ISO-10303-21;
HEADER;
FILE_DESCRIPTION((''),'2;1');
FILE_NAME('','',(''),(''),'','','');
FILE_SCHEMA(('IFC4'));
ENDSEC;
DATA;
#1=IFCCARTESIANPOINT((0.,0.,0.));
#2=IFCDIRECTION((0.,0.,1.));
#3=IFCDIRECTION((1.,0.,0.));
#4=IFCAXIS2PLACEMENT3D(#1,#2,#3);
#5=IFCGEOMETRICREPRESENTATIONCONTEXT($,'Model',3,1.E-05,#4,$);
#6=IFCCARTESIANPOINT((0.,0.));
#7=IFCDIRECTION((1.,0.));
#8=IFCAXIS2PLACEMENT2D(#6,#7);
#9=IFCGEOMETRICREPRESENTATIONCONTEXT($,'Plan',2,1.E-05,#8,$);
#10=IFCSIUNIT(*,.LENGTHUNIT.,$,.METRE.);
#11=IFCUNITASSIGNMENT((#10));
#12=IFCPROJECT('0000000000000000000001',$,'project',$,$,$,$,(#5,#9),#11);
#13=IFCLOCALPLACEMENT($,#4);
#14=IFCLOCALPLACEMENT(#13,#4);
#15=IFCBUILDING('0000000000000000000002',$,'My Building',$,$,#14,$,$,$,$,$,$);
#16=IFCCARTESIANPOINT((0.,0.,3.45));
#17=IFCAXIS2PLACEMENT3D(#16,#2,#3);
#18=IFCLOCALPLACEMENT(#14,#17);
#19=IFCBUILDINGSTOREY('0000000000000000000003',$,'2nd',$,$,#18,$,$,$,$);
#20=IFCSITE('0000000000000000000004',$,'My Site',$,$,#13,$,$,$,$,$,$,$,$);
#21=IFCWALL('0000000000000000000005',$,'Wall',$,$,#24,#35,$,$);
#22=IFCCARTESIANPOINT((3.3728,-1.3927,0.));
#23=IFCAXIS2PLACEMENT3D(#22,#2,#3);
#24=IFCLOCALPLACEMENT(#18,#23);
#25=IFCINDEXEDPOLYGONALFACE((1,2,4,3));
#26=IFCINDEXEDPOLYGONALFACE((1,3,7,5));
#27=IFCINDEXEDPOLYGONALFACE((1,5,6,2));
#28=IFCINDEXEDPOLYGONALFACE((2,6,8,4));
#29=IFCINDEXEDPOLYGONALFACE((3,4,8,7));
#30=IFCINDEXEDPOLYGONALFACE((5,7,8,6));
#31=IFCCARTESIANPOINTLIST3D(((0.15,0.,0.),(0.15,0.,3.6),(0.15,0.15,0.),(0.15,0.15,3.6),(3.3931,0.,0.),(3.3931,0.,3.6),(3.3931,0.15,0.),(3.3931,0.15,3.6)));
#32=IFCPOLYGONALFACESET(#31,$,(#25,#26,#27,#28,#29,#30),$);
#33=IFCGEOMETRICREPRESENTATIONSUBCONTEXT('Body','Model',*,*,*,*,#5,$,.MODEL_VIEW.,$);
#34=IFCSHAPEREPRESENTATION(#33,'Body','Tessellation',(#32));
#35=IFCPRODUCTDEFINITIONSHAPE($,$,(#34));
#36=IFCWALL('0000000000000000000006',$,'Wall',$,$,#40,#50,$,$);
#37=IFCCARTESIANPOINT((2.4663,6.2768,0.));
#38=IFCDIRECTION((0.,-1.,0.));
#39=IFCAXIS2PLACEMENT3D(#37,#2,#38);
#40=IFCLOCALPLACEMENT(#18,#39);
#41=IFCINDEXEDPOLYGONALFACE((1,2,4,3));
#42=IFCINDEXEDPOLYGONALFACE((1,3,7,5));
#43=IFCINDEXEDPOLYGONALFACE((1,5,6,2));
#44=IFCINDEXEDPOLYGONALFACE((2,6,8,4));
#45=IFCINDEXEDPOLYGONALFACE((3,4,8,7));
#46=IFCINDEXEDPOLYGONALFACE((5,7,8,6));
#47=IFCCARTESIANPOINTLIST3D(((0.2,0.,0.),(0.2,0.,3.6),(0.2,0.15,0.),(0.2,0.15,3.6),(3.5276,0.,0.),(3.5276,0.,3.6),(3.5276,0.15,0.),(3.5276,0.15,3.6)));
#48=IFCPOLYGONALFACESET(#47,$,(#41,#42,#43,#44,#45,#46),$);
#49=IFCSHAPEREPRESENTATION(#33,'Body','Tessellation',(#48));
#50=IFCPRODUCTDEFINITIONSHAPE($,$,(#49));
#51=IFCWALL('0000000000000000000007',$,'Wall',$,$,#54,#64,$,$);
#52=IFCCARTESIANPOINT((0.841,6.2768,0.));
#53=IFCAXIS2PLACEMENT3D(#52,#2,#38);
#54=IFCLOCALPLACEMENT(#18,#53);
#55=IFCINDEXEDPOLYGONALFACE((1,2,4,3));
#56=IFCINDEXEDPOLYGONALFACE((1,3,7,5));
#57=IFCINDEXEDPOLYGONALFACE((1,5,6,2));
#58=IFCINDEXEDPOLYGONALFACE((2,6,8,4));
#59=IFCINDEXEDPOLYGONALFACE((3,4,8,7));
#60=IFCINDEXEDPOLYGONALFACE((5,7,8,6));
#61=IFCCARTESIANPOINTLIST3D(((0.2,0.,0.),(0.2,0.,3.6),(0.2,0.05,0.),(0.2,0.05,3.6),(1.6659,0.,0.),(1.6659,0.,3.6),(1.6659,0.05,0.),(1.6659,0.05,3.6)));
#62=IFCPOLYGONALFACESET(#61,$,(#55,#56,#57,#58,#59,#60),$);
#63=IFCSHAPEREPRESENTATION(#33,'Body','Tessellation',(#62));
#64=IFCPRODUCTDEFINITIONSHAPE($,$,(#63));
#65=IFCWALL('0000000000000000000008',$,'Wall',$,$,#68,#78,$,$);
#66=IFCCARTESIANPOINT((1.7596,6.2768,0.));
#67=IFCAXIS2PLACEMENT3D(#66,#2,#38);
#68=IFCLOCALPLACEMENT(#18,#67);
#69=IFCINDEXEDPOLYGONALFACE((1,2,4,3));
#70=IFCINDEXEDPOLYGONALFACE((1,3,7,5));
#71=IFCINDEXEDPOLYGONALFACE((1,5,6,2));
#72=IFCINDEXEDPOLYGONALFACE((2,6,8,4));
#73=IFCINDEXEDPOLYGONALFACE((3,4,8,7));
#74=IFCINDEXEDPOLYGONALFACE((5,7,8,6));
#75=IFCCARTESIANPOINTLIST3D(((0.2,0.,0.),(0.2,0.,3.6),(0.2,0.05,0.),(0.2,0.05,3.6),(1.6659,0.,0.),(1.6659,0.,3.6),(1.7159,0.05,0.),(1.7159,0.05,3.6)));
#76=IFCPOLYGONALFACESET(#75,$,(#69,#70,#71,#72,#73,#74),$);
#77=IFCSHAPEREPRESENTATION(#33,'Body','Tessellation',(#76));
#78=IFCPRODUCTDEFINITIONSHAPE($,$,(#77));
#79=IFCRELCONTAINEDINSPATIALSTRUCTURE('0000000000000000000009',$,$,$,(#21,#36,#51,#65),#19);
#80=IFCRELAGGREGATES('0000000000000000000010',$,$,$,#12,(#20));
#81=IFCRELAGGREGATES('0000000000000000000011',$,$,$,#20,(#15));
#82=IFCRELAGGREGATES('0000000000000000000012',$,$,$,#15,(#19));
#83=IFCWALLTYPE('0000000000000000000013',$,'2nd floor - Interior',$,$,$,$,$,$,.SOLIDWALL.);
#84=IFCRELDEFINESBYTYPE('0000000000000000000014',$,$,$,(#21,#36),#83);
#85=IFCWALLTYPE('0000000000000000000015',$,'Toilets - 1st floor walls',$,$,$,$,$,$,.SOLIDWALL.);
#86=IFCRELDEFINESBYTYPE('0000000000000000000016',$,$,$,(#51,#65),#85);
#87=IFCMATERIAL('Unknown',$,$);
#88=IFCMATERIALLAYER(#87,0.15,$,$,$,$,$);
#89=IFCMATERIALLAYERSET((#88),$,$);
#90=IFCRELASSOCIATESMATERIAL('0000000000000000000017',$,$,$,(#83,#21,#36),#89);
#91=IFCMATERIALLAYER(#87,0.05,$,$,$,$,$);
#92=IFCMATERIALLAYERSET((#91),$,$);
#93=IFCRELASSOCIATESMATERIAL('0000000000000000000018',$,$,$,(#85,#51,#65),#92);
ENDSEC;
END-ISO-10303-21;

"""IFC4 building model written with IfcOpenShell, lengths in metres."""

from ifc_helpers import new_model, si_unit, frame, origin_with_axes, origin_2d_with_axis, place, context, subcontext, project, spatial, line, indexed_curve, outline, extrude, material, layer, layer_set, layer_usage, type_object, element, save


model = new_model("IFC4")

# Units and contexts
model_context = context("Model", 3, precision=1e-05, world=origin_with_axes())
plan_context = context("Plan", 2, precision=1e-05, world=origin_2d_with_axis())
body_context_1 = subcontext(model_context, "Body", "Model", "MODEL_VIEW")
ifc_project = project(units=[si_unit("LENGTHUNIT", "METRE")], contexts=[model_context, plan_context])

# Site, building, storey
site_placement = place(None, origin_with_axes())
site = spatial("IfcSite", under=ifc_project, at=site_placement, Name="My Site")
building_placement = place(site_placement, origin_with_axes())
building = spatial("IfcBuilding", under=site, at=building_placement, Name="My Building")
storey_placement = place(building_placement, frame((0.0, 0.0, 3.45), z_axis=(0.0, 0.0, 1.0), x_axis=(1.0, 0.0, 0.0)))
storey = spatial("IfcBuildingStorey", under=building, at=storey_placement, Name="2nd")

# Shared definitions
ifc_material = material(Name="Unknown")

# Shared definitions
ifc_layer_1 = layer(ifc_material, 0.15)
ifc_layer_set_1 = layer_set([ifc_layer_1])
wall_type_1 = type_object("IfcWallType", Name="2nd floor - Interior", PredefinedType="SOLIDWALL", material=ifc_layer_set_1)

# Walls
ifc_layer_usage_1 = layer_usage(ifc_layer_set_1, "AXIS2", "POSITIVE", 0.0)
wall_1_placement = place(storey_placement, frame((3.3728, -1.3927, 0.0), z_axis=(0.0, 0.0, 1.0), x_axis=(1.0, 0.0, 0.0)))
element("IfcWall", 1, at=wall_1_placement, inside=storey, type_object=wall_type_1, material=ifc_layer_usage_1, Name="Wall", context=body_context_1, shape_type="SweptSolid", body=[
    extrude(outline(indexed_curve([(0.15, 0.0), (0.15, 0.15), (3.3931, 0.15), (3.3931, 0.0)], segments=[line(1, 2, 3, 4, 1)])), origin_with_axes(), (0.0, 0.0, 1.0), 3.6),
])
ifc_layer_usage_2 = layer_usage(ifc_layer_set_1, "AXIS2", "POSITIVE", 0.0)
wall_2_placement = place(storey_placement, frame((2.4663, 6.2768, 0.0), z_axis=(0.0, 0.0, 1.0), x_axis=(0.0, -1.0, 0.0)))
element("IfcWall", 2, at=wall_2_placement, inside=storey, type_object=wall_type_1, material=ifc_layer_usage_2, Name="Wall", context=body_context_1, shape_type="SweptSolid", body=[
    extrude(outline(indexed_curve([(0.2, 0.0), (0.2, 0.15), (3.5276, 0.15), (3.5276, 0.0)], segments=[line(1, 2, 3, 4, 1)])), origin_with_axes(), (0.0, 0.0, 1.0), 3.6),
])
ifc_layer_2 = layer(ifc_material, 0.05)
ifc_layer_set_2 = layer_set([ifc_layer_2])
ifc_layer_usage_3 = layer_usage(ifc_layer_set_2, "AXIS2", "POSITIVE", 0.0)
wall_type_2 = type_object("IfcWallType", Name="Toilets - 1st floor walls", PredefinedType="SOLIDWALL", material=ifc_layer_set_2)
wall_3_placement = place(storey_placement, frame((0.841, 6.2768, 0.0), z_axis=(0.0, 0.0, 1.0), x_axis=(0.0, -1.0, 0.0)))
element("IfcWall", 3, at=wall_3_placement, inside=storey, type_object=wall_type_2, material=ifc_layer_usage_3, Name="Wall", context=body_context_1, shape_type="SweptSolid", body=[
    extrude(outline(indexed_curve([(0.2, 0.0), (0.2, 0.05), (1.6659, 0.05), (1.6659, 0.0)], segments=[line(1, 2, 3, 4, 1)])), origin_with_axes(), (0.0, 0.0, 1.0), 3.6),
])
ifc_layer_usage_4 = layer_usage(ifc_layer_set_2, "AXIS2", "POSITIVE", 0.0)
wall_4_placement = place(storey_placement, frame((1.7596, 6.2768, 0.0), z_axis=(0.0, 0.0, 1.0), x_axis=(0.0, -1.0, 0.0)))
element("IfcWall", 4, at=wall_4_placement, inside=storey, type_object=wall_type_2, material=ifc_layer_usage_4, Name="Wall", context=body_context_1, shape_type="SweptSolid", body=[
    extrude(outline(indexed_curve([(0.2, 0.0), (0.2, 0.05), (1.7159, 0.05), (1.6659, 0.0)], segments=[line(1, 2, 3, 4, 1)])), origin_with_axes(), (0.0, 0.0, 1.0), 3.6),
])

save(model, "model.ifc")
